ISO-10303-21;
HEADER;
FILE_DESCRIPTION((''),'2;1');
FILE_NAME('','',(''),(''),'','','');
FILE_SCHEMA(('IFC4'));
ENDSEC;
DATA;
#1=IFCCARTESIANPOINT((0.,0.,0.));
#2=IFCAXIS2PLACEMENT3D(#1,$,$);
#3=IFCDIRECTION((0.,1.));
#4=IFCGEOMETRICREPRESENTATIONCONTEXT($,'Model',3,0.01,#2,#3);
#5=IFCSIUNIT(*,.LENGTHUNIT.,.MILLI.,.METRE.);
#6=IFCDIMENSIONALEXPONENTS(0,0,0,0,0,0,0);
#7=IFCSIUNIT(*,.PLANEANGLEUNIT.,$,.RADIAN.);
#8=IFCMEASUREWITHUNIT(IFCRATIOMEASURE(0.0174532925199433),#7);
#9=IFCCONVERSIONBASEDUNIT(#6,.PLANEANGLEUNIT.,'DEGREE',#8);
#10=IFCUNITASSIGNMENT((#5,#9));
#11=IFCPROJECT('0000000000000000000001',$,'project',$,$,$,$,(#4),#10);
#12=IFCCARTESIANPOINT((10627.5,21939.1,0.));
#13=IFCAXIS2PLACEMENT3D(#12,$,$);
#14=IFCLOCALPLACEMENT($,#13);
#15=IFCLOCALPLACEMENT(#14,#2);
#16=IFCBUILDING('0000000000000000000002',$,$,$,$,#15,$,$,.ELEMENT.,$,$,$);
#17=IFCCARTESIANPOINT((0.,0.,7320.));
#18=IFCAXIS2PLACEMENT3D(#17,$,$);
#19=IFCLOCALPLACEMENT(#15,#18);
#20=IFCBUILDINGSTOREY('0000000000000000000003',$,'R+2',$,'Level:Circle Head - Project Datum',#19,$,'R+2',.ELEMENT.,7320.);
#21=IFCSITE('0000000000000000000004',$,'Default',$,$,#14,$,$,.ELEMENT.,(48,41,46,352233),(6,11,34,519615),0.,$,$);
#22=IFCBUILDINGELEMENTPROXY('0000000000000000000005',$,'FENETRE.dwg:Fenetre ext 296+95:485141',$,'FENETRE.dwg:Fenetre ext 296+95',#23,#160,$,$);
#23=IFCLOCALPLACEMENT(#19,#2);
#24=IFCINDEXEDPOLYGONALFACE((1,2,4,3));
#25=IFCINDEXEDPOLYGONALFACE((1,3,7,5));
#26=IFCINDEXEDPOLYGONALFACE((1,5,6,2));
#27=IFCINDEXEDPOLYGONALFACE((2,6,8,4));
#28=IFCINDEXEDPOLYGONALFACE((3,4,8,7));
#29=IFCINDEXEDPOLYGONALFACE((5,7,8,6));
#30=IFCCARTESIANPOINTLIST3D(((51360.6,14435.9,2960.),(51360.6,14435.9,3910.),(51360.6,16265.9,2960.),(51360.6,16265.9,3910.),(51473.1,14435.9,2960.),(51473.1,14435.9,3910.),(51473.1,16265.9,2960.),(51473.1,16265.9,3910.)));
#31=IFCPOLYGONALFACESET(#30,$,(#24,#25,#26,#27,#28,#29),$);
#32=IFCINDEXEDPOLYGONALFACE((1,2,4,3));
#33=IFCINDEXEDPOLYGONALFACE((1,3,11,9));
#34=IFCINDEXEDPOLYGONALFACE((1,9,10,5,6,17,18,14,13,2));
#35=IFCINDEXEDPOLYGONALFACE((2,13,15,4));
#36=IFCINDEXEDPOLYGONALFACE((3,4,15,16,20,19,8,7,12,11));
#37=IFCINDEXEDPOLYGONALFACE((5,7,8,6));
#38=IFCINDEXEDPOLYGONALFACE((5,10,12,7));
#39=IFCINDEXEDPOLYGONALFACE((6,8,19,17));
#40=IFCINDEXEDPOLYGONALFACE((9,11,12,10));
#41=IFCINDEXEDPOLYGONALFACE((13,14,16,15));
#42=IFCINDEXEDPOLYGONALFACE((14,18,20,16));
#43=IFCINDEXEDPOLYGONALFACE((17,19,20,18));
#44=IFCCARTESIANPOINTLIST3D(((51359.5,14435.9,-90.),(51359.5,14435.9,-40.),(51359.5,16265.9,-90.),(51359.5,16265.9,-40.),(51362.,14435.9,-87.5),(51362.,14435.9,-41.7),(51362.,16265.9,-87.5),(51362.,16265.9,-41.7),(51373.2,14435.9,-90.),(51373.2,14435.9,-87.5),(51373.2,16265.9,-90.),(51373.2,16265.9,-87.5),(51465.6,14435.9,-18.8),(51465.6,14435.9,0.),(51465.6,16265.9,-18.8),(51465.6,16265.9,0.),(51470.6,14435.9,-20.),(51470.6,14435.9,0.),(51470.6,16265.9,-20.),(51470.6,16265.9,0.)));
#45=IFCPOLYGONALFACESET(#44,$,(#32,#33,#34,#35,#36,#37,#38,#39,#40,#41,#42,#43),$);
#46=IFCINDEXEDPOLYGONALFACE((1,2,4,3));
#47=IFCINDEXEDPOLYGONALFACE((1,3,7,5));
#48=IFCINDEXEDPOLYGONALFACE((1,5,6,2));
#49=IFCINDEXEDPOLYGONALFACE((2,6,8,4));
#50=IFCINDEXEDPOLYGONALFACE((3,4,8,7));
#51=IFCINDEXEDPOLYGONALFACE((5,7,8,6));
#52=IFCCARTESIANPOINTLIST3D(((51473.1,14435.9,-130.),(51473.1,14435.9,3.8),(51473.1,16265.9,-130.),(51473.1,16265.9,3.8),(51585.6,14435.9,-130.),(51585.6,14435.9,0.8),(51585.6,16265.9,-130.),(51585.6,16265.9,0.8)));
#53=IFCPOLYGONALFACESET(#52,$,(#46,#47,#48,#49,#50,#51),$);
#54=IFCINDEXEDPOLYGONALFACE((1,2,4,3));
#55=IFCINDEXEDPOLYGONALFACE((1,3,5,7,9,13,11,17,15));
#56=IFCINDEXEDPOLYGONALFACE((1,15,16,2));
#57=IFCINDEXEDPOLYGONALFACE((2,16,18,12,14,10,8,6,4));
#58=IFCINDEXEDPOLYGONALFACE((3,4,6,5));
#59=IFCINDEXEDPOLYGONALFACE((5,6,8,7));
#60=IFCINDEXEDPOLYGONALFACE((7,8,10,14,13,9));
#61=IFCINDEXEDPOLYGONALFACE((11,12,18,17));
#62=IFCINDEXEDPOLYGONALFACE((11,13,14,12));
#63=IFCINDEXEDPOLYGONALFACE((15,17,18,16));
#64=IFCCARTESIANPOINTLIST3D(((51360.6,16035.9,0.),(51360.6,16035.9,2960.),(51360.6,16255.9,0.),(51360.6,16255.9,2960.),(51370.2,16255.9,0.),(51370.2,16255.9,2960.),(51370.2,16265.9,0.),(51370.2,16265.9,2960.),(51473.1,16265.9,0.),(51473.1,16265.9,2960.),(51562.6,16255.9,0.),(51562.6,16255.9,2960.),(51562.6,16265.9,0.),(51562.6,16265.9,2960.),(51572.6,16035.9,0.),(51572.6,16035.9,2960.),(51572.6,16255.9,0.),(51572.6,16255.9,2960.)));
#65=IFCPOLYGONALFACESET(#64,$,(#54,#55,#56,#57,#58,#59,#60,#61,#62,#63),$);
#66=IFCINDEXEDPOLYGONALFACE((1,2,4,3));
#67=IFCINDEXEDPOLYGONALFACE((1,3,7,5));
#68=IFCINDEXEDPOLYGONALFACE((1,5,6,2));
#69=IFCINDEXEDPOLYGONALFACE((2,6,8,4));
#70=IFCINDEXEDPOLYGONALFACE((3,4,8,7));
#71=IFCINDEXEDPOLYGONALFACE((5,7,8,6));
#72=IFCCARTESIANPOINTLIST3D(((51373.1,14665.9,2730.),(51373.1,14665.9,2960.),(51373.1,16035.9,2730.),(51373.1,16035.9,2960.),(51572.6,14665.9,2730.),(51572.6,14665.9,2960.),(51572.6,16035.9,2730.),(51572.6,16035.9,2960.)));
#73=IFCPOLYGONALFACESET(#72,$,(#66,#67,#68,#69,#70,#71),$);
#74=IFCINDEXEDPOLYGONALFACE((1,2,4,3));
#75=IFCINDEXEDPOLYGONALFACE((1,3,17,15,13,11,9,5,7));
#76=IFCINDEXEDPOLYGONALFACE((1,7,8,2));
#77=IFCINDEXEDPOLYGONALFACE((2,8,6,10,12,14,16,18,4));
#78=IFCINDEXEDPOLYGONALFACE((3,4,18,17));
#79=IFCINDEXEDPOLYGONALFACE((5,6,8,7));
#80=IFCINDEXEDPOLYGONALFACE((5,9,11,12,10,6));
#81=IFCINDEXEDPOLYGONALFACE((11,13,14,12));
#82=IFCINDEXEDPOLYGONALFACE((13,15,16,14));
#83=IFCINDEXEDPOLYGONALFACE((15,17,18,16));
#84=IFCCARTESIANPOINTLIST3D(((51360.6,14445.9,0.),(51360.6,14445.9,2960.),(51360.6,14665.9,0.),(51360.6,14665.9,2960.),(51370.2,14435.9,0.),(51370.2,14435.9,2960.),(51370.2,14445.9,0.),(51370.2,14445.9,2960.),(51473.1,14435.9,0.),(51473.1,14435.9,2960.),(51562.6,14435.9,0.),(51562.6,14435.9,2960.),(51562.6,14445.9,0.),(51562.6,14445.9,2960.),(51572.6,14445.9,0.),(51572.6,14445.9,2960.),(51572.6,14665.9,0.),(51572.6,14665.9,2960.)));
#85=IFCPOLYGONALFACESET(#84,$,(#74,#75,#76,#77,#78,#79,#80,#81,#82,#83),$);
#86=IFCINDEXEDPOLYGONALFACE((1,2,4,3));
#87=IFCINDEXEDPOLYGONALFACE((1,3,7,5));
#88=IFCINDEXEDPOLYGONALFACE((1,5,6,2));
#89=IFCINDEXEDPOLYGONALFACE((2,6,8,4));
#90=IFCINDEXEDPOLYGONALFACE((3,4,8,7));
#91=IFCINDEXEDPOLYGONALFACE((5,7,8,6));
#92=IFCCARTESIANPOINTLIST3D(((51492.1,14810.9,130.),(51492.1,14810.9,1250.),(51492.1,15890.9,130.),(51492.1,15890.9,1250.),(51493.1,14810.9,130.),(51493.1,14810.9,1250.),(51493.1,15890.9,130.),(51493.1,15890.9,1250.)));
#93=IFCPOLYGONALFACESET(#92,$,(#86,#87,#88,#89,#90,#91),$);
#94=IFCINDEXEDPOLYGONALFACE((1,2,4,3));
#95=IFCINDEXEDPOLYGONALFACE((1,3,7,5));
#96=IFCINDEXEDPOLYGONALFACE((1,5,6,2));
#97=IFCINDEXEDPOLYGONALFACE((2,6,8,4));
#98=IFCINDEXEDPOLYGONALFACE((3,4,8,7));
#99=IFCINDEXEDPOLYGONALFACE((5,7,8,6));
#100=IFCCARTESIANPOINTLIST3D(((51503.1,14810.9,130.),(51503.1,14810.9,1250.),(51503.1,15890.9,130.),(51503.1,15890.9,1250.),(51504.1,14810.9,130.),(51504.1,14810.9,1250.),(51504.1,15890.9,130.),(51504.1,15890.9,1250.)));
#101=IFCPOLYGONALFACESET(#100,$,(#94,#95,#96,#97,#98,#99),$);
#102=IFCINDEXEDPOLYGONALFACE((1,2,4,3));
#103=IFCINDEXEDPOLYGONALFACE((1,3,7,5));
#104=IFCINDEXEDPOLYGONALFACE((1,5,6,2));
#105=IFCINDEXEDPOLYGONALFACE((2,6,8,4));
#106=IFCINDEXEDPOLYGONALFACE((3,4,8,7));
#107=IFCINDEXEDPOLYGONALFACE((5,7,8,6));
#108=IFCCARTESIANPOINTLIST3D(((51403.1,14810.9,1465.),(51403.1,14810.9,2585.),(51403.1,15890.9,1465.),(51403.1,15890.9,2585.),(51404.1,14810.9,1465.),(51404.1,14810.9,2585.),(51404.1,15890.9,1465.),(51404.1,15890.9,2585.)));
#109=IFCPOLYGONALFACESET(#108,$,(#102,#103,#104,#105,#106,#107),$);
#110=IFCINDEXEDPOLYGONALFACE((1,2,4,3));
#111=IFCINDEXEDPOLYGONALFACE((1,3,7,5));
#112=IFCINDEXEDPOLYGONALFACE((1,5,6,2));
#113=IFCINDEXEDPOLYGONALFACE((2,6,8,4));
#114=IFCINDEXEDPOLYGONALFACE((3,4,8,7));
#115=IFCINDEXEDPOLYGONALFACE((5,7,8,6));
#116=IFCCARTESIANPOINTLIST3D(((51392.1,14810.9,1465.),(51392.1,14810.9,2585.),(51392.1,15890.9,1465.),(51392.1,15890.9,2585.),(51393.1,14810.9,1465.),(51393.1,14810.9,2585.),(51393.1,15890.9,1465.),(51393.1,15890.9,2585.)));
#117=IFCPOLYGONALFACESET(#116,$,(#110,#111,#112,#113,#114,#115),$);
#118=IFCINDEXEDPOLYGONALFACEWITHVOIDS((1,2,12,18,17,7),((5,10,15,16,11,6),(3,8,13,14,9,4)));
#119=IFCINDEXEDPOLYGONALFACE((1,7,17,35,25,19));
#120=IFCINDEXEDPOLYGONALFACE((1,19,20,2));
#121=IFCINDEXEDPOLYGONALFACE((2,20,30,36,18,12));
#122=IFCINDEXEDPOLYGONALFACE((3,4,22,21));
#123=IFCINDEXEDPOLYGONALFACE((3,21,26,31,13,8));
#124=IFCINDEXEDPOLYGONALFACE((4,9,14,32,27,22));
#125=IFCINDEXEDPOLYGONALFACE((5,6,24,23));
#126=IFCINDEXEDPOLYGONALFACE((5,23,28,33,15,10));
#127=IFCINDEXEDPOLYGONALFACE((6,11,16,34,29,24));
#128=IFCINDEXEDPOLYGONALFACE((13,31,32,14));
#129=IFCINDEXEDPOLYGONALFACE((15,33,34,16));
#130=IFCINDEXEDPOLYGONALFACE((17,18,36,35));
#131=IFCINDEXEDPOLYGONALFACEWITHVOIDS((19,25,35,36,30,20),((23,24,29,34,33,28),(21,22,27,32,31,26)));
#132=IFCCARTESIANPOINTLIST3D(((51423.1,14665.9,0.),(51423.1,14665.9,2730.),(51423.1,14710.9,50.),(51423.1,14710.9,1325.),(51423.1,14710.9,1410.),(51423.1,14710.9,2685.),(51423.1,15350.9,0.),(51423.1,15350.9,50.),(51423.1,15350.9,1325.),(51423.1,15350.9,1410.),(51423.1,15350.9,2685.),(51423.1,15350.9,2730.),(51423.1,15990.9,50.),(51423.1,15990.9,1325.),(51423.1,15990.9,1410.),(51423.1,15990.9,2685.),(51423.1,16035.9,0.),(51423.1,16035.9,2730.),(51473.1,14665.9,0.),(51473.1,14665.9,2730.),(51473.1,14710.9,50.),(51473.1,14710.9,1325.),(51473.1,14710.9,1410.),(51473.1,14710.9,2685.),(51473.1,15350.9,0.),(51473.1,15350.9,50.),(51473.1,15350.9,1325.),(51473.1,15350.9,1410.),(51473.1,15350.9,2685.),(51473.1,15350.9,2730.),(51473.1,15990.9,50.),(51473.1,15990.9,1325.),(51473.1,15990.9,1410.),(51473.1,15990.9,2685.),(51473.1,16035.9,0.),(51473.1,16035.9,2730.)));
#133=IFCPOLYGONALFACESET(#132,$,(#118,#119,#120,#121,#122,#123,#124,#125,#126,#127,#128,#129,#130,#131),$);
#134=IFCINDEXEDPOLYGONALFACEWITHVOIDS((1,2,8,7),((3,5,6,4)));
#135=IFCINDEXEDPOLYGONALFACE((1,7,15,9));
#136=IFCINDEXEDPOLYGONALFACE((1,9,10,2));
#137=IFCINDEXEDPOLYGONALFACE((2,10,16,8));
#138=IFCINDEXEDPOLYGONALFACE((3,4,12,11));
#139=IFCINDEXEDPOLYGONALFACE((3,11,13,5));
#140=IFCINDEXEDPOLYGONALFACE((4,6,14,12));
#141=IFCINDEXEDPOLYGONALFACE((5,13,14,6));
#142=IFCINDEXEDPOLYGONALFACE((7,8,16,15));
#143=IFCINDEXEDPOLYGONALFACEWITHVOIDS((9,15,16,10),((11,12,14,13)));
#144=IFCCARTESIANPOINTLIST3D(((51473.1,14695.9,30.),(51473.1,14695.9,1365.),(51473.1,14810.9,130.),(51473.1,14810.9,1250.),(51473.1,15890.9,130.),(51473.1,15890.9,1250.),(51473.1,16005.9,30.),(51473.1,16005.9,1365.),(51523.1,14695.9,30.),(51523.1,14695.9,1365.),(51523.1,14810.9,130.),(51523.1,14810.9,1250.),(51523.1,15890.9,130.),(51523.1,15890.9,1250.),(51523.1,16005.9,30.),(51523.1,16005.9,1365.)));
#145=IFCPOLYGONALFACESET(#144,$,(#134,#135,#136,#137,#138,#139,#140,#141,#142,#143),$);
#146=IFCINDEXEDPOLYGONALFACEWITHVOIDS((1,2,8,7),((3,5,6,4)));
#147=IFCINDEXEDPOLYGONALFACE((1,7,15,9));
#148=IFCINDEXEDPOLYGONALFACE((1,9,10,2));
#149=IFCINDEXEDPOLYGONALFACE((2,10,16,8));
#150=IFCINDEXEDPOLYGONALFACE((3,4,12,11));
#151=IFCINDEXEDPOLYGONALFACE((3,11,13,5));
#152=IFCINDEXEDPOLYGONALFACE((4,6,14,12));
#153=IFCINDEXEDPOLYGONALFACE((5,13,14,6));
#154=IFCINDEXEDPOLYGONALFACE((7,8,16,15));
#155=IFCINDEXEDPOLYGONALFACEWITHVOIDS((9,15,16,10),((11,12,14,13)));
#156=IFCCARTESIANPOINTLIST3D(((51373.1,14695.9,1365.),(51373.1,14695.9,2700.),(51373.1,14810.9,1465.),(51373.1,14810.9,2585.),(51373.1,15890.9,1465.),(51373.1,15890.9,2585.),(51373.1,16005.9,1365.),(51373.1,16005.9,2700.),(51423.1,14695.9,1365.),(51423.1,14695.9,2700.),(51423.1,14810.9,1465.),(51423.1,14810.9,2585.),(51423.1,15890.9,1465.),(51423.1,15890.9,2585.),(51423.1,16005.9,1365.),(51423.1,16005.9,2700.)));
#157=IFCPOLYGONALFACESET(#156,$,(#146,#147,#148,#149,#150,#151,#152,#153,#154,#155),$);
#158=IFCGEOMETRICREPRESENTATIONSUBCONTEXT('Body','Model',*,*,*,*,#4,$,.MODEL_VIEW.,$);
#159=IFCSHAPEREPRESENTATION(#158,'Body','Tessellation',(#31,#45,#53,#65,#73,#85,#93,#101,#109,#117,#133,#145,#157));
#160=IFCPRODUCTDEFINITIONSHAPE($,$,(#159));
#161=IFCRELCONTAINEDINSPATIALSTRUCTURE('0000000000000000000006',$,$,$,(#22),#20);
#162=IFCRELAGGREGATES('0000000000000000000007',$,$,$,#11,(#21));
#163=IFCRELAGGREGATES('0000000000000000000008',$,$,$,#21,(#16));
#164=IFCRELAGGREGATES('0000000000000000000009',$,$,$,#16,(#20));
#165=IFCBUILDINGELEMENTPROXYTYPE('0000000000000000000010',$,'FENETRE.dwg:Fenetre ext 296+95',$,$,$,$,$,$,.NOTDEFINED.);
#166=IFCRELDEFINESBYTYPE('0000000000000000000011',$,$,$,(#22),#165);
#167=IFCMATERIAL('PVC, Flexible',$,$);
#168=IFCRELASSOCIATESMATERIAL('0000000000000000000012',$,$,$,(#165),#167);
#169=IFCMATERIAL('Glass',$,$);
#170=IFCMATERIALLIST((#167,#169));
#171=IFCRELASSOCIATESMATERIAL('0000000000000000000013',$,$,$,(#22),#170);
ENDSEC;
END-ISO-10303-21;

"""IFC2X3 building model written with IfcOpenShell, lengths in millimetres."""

from ifc_helpers import new_model, entity, si_unit, converted_unit, direction, frame, frame_2d, origin, origin_2d_with_axis, place, context, subcontext, project, spatial, polyline, rectangle, outline, extrude, source, transform, mapped, material, material_list, type_object, type_shapes, element, save


model = new_model("IFC2X3")

# Units and contexts
model_context = context("Model", 3, precision=0.01, world=origin(), true_north=direction((0.0, 1.0)))
body_context = subcontext(model_context, "Body", "Model", "MODEL_VIEW")
ifc_project = project(units=[si_unit("LENGTHUNIT", "METRE", prefix="MILLI"), converted_unit("PLANEANGLEUNIT", "DEGREE", entity("IfcRatioMeasure", 0.0174532925199433), si_unit("PLANEANGLEUNIT", "RADIAN"), dimensions=[0, 0, 0, 0, 0, 0, 0])], contexts=[model_context])

# Site, building, storey
site_placement = place(None, frame((10627.5, 21939.1, 0.0)))
site = spatial("IfcSite", under=ifc_project, at=site_placement, Name="Default", CompositionType="ELEMENT", RefLatitude=(48, 41, 46, 352233), RefLongitude=(6, 11, 34, 519615), RefElevation=0.0)
building_placement = place(site_placement, origin())
building = spatial("IfcBuilding", under=site, at=building_placement, CompositionType="ELEMENT")
storey_placement = place(building_placement, frame((0.0, 0.0, 7320.0)))
storey = spatial("IfcBuildingStorey", under=building, at=storey_placement, Name="R+2", ObjectType="Level:Circle Head - Project Datum", LongName="R+2", CompositionType="ELEMENT", Elevation=7320.0)

# Building element proxy
ifc_material_1 = material(Name="PVC, Flexible")
ifc_material_2 = material(Name="Glass")
building_element_proxy_type_1 = type_object("IfcBuildingElementProxyType", Name="FENETRE.dwg:Fenetre ext 296+95", PredefinedType="NOTDEFINED", material=ifc_material_1)
shared_shape_1 = source(origin(), body_context, "Body", "SweptSolid", [
    extrude(rectangle(XDim=1830.0, YDim=112.5, at=origin_2d_with_axis()), frame((-10.4, 56.3, 2960.0), z_axis=(0.0, 0.0, 1.0), x_axis=(-1.0, 0.0, 0.0)), (0.0, 0.0, 1.0), 950.0),
    extrude(outline(polyline([(-68.6, -14.4), (-72.5, -34.0), (-67.6, -35.0), (-63.9, -16.6), (44.3, -16.6), (54.1, 32.5), (40.6, 35.2), (40.1, 32.7), (51.2, 30.5), (42.2, -14.4), (-68.6, -14.4)])), frame((-925.4, 66.9, -47.5), z_axis=(-1.0, 0.0, 0.0), x_axis=(0.0, 0.980599, -0.196027)), (0.0, 0.0, -1.0), 1830.0),
    extrude(outline(polyline([(-64.7, -56.3), (66.2, -56.3), (66.2, 56.3), (-67.7, 56.3), (-64.7, -56.3)])), frame((-925.4, -56.3, -63.8), z_axis=(1.0, 0.0, 0.0), x_axis=(0.0, 0.0, -1.0)), (0.0, 0.0, 1.0), 1830.0),
    extrude(outline(polyline([(-55.6, 97.0), (-55.6, -5.9), (-55.6, -95.4), (-45.6, -95.4), (-45.6, -105.4), (174.4, -105.4), (174.4, 106.6), (-45.6, 106.6), (-45.6, 97.0), (-55.6, 97.0)])), frame((849.0, 5.9, 0.0), z_axis=(0.0, 0.0, -1.0), x_axis=(-1.0, 0.0, 0.0)), (0.0, 0.0, -1.0), 2960.0),
    extrude(rectangle(XDim=199.5, YDim=1370.0, at=origin_2d_with_axis()), frame((-10.4, 0.3, 2730.0), z_axis=(0.0, 0.0, 1.0), x_axis=(0.0, 1.0, 0.0)), (0.0, 0.0, 1.0), 230.0),
    extrude(outline(polyline([(-97.0, -55.6), (5.9, -55.6), (95.4, -55.6), (95.4, -45.6), (105.4, -45.6), (105.4, 174.4), (-106.6, 174.4), (-106.6, -45.6), (-97.0, -45.6), (-97.0, -55.6)])), frame((-869.9, 5.9, 0.0), z_axis=(0.0, 0.0, 1.0), x_axis=(0.0, -1.0, 0.0)), (0.0, 0.0, 1.0), 2960.0),
    extrude(rectangle(XDim=1.0, YDim=1080.0, at=origin_2d_with_axis()), frame((-10.4, -19.5, 130.0), z_axis=(0.0, 0.0, 1.0), x_axis=(0.0, 1.0, 0.0)), (0.0, 0.0, 1.0), 1120.0),
    extrude(rectangle(XDim=1.0, YDim=1080.0, at=frame_2d((0.0, 0.0), x_axis=(1.0, 0.0))), frame((-10.4, -30.5, 130.0), z_axis=(0.0, 0.0, 1.0), x_axis=(0.0, 1.0, 0.0)), (0.0, 0.0, 1.0), 1120.0),
    extrude(rectangle(XDim=1.0, YDim=1080.0, at=frame_2d((0.0, 0.0), x_axis=(1.0, 0.0))), frame((-10.4, 69.5, 1465.0), z_axis=(0.0, 0.0, 1.0), x_axis=(0.0, 1.0, 0.0)), (0.0, 0.0, 1.0), 1120.0),
    extrude(rectangle(XDim=1.0, YDim=1080.0, at=frame_2d((0.0, 0.0), x_axis=(1.0, 0.0))), frame((-10.4, 80.5, 1465.0), z_axis=(0.0, 0.0, 1.0), x_axis=(0.0, 1.0, 0.0)), (0.0, 0.0, 1.0), 1120.0),
    extrude(outline(polyline([(-685.0, -1365.0), (0.0, -1365.0), (685.0, -1365.0), (685.0, 1365.0), (0.0, 1365.0), (-685.0, 1365.0), (-685.0, -1365.0)]), holes=[polyline([(-640.0, -1320.0), (-640.0, -45.0), (0.0, -45.0), (640.0, -45.0), (640.0, -1320.0), (0.0, -1320.0), (-640.0, -1320.0)]), polyline([(-640.0, 40.0), (-640.0, 1315.0), (0.0, 1315.0), (640.0, 1315.0), (640.0, 40.0), (0.0, 40.0), (-640.0, 40.0)])]), frame((-10.4, 0.0, 1365.0), z_axis=(0.0, 1.0, 0.0), x_axis=(1.0, 0.0, 0.0)), (0.0, 0.0, 1.0), 50.0),
    extrude(outline(polyline([(-655.0, -667.5), (655.0, -667.5), (655.0, 667.5), (-655.0, 667.5), (-655.0, -667.5)]), holes=[polyline([(-540.0, 552.5), (540.0, 552.5), (540.0, -567.5), (-540.0, -567.5), (-540.0, 552.5)])]), frame((-10.4, -50.0, 697.5), z_axis=(0.0, 1.0, 0.0), x_axis=(-1.0, 0.0, 0.0)), (0.0, 0.0, 1.0), 50.0),
    extrude(outline(polyline([(-655.0, -667.5), (655.0, -667.5), (655.0, 667.5), (-655.0, 667.5), (-655.0, -667.5)]), holes=[polyline([(-540.0, 552.5), (540.0, 552.5), (540.0, -567.5), (-540.0, -567.5), (-540.0, 552.5)])]), frame((-10.4, 50.0, 2032.5), z_axis=(0.0, 1.0, 0.0), x_axis=(-1.0, 0.0, 0.0)), (0.0, 0.0, 1.0), 50.0),
])
type_shapes(building_element_proxy_type_1, [shared_shape_1])
ifc_material_list_1 = material_list([ifc_material_1, ifc_material_2])
proxy_1_placement = place(storey_placement, frame((51473.1, 15361.3, 0.0), z_axis=(0.0, 0.0, 1.0), x_axis=(0.0, 1.0, 0.0)))
element("IfcBuildingElementProxy", 1, at=proxy_1_placement, inside=storey, type_object=building_element_proxy_type_1, material=ifc_material_list_1, Name="FENETRE.dwg:Fenetre ext 296+95:485141", ObjectType="FENETRE.dwg:Fenetre ext 296+95", context=body_context, shape_type="MappedRepresentation", body=[
    mapped(shared_shape_1, transform((0.0, 0.0, 0.0), scale=1.0)),
])

save(model, "model.ifc")
